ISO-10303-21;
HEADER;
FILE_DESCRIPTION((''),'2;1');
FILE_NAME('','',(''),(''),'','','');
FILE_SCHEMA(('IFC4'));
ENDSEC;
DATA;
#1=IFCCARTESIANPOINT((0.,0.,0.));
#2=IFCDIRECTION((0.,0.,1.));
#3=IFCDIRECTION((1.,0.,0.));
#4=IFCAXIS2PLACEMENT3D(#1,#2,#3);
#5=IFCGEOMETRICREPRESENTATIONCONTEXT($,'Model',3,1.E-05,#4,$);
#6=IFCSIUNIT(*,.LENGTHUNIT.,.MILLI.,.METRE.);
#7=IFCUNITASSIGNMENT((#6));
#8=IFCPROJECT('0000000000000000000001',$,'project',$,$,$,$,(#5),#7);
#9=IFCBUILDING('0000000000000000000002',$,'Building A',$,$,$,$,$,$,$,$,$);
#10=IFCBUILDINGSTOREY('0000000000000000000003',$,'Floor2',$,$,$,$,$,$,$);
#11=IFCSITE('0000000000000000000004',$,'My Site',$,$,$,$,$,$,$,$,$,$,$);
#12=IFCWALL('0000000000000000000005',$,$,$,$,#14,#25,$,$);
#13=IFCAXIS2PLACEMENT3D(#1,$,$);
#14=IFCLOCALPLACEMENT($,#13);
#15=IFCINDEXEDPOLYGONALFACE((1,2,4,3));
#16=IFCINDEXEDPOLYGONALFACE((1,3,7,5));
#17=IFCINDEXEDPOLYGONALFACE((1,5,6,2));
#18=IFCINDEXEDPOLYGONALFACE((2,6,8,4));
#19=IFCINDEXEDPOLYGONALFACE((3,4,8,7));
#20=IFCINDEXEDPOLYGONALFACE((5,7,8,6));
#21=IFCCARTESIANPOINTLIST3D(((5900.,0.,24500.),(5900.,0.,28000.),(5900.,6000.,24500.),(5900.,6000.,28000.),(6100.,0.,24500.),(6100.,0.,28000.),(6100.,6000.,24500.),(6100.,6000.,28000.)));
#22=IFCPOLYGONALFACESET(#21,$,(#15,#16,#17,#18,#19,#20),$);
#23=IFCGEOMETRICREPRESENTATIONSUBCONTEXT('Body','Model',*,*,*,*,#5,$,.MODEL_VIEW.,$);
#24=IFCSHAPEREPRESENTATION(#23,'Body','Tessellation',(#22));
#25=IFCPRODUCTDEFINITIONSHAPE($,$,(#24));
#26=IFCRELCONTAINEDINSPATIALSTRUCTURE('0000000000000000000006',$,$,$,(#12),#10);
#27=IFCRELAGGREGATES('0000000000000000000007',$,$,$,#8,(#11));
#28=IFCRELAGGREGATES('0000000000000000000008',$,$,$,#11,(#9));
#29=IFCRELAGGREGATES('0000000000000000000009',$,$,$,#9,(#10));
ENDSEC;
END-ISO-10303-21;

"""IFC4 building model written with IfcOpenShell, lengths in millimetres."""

from ifc_helpers import new_model, si_unit, frame, origin_with_axes, place, context, subcontext, project, spatial, indexed_curve, outline, extrude, element, save


model = new_model("IFC4")

# Units and contexts
model_context = context("Model", 3, precision=1e-05, world=origin_with_axes())
body_context = subcontext(model_context, "Body", "Model", "MODEL_VIEW")
ifc_project = project(units=[si_unit("LENGTHUNIT", "METRE", prefix="MILLI")], contexts=[model_context])

# Site, building, storey
site = spatial("IfcSite", under=ifc_project, Name="My Site")
building = spatial("IfcBuilding", under=site, Name="Building A")
storey = spatial("IfcBuildingStorey", under=building, Name="Floor2")

# Wall
wall_placement = place(None, frame((6100.0, 0.0, 24500.0), z_axis=(0.0, 0.0, 1.0), x_axis=(0.0, 1.0, 0.0)))
element("IfcWall", 1, at=wall_placement, inside=storey, context=body_context, shape_type="SweptSolid", body=[
    extrude(outline(indexed_curve([(0.0, 0.0), (0.0, 200.0), (6000.0, 200.0), (6000.0, 0.0), (0.0, 0.0)], self_intersect=False)), origin_with_axes(), (0.0, 0.0, 1.0), 3500.0),
])

save(model, "model.ifc")
